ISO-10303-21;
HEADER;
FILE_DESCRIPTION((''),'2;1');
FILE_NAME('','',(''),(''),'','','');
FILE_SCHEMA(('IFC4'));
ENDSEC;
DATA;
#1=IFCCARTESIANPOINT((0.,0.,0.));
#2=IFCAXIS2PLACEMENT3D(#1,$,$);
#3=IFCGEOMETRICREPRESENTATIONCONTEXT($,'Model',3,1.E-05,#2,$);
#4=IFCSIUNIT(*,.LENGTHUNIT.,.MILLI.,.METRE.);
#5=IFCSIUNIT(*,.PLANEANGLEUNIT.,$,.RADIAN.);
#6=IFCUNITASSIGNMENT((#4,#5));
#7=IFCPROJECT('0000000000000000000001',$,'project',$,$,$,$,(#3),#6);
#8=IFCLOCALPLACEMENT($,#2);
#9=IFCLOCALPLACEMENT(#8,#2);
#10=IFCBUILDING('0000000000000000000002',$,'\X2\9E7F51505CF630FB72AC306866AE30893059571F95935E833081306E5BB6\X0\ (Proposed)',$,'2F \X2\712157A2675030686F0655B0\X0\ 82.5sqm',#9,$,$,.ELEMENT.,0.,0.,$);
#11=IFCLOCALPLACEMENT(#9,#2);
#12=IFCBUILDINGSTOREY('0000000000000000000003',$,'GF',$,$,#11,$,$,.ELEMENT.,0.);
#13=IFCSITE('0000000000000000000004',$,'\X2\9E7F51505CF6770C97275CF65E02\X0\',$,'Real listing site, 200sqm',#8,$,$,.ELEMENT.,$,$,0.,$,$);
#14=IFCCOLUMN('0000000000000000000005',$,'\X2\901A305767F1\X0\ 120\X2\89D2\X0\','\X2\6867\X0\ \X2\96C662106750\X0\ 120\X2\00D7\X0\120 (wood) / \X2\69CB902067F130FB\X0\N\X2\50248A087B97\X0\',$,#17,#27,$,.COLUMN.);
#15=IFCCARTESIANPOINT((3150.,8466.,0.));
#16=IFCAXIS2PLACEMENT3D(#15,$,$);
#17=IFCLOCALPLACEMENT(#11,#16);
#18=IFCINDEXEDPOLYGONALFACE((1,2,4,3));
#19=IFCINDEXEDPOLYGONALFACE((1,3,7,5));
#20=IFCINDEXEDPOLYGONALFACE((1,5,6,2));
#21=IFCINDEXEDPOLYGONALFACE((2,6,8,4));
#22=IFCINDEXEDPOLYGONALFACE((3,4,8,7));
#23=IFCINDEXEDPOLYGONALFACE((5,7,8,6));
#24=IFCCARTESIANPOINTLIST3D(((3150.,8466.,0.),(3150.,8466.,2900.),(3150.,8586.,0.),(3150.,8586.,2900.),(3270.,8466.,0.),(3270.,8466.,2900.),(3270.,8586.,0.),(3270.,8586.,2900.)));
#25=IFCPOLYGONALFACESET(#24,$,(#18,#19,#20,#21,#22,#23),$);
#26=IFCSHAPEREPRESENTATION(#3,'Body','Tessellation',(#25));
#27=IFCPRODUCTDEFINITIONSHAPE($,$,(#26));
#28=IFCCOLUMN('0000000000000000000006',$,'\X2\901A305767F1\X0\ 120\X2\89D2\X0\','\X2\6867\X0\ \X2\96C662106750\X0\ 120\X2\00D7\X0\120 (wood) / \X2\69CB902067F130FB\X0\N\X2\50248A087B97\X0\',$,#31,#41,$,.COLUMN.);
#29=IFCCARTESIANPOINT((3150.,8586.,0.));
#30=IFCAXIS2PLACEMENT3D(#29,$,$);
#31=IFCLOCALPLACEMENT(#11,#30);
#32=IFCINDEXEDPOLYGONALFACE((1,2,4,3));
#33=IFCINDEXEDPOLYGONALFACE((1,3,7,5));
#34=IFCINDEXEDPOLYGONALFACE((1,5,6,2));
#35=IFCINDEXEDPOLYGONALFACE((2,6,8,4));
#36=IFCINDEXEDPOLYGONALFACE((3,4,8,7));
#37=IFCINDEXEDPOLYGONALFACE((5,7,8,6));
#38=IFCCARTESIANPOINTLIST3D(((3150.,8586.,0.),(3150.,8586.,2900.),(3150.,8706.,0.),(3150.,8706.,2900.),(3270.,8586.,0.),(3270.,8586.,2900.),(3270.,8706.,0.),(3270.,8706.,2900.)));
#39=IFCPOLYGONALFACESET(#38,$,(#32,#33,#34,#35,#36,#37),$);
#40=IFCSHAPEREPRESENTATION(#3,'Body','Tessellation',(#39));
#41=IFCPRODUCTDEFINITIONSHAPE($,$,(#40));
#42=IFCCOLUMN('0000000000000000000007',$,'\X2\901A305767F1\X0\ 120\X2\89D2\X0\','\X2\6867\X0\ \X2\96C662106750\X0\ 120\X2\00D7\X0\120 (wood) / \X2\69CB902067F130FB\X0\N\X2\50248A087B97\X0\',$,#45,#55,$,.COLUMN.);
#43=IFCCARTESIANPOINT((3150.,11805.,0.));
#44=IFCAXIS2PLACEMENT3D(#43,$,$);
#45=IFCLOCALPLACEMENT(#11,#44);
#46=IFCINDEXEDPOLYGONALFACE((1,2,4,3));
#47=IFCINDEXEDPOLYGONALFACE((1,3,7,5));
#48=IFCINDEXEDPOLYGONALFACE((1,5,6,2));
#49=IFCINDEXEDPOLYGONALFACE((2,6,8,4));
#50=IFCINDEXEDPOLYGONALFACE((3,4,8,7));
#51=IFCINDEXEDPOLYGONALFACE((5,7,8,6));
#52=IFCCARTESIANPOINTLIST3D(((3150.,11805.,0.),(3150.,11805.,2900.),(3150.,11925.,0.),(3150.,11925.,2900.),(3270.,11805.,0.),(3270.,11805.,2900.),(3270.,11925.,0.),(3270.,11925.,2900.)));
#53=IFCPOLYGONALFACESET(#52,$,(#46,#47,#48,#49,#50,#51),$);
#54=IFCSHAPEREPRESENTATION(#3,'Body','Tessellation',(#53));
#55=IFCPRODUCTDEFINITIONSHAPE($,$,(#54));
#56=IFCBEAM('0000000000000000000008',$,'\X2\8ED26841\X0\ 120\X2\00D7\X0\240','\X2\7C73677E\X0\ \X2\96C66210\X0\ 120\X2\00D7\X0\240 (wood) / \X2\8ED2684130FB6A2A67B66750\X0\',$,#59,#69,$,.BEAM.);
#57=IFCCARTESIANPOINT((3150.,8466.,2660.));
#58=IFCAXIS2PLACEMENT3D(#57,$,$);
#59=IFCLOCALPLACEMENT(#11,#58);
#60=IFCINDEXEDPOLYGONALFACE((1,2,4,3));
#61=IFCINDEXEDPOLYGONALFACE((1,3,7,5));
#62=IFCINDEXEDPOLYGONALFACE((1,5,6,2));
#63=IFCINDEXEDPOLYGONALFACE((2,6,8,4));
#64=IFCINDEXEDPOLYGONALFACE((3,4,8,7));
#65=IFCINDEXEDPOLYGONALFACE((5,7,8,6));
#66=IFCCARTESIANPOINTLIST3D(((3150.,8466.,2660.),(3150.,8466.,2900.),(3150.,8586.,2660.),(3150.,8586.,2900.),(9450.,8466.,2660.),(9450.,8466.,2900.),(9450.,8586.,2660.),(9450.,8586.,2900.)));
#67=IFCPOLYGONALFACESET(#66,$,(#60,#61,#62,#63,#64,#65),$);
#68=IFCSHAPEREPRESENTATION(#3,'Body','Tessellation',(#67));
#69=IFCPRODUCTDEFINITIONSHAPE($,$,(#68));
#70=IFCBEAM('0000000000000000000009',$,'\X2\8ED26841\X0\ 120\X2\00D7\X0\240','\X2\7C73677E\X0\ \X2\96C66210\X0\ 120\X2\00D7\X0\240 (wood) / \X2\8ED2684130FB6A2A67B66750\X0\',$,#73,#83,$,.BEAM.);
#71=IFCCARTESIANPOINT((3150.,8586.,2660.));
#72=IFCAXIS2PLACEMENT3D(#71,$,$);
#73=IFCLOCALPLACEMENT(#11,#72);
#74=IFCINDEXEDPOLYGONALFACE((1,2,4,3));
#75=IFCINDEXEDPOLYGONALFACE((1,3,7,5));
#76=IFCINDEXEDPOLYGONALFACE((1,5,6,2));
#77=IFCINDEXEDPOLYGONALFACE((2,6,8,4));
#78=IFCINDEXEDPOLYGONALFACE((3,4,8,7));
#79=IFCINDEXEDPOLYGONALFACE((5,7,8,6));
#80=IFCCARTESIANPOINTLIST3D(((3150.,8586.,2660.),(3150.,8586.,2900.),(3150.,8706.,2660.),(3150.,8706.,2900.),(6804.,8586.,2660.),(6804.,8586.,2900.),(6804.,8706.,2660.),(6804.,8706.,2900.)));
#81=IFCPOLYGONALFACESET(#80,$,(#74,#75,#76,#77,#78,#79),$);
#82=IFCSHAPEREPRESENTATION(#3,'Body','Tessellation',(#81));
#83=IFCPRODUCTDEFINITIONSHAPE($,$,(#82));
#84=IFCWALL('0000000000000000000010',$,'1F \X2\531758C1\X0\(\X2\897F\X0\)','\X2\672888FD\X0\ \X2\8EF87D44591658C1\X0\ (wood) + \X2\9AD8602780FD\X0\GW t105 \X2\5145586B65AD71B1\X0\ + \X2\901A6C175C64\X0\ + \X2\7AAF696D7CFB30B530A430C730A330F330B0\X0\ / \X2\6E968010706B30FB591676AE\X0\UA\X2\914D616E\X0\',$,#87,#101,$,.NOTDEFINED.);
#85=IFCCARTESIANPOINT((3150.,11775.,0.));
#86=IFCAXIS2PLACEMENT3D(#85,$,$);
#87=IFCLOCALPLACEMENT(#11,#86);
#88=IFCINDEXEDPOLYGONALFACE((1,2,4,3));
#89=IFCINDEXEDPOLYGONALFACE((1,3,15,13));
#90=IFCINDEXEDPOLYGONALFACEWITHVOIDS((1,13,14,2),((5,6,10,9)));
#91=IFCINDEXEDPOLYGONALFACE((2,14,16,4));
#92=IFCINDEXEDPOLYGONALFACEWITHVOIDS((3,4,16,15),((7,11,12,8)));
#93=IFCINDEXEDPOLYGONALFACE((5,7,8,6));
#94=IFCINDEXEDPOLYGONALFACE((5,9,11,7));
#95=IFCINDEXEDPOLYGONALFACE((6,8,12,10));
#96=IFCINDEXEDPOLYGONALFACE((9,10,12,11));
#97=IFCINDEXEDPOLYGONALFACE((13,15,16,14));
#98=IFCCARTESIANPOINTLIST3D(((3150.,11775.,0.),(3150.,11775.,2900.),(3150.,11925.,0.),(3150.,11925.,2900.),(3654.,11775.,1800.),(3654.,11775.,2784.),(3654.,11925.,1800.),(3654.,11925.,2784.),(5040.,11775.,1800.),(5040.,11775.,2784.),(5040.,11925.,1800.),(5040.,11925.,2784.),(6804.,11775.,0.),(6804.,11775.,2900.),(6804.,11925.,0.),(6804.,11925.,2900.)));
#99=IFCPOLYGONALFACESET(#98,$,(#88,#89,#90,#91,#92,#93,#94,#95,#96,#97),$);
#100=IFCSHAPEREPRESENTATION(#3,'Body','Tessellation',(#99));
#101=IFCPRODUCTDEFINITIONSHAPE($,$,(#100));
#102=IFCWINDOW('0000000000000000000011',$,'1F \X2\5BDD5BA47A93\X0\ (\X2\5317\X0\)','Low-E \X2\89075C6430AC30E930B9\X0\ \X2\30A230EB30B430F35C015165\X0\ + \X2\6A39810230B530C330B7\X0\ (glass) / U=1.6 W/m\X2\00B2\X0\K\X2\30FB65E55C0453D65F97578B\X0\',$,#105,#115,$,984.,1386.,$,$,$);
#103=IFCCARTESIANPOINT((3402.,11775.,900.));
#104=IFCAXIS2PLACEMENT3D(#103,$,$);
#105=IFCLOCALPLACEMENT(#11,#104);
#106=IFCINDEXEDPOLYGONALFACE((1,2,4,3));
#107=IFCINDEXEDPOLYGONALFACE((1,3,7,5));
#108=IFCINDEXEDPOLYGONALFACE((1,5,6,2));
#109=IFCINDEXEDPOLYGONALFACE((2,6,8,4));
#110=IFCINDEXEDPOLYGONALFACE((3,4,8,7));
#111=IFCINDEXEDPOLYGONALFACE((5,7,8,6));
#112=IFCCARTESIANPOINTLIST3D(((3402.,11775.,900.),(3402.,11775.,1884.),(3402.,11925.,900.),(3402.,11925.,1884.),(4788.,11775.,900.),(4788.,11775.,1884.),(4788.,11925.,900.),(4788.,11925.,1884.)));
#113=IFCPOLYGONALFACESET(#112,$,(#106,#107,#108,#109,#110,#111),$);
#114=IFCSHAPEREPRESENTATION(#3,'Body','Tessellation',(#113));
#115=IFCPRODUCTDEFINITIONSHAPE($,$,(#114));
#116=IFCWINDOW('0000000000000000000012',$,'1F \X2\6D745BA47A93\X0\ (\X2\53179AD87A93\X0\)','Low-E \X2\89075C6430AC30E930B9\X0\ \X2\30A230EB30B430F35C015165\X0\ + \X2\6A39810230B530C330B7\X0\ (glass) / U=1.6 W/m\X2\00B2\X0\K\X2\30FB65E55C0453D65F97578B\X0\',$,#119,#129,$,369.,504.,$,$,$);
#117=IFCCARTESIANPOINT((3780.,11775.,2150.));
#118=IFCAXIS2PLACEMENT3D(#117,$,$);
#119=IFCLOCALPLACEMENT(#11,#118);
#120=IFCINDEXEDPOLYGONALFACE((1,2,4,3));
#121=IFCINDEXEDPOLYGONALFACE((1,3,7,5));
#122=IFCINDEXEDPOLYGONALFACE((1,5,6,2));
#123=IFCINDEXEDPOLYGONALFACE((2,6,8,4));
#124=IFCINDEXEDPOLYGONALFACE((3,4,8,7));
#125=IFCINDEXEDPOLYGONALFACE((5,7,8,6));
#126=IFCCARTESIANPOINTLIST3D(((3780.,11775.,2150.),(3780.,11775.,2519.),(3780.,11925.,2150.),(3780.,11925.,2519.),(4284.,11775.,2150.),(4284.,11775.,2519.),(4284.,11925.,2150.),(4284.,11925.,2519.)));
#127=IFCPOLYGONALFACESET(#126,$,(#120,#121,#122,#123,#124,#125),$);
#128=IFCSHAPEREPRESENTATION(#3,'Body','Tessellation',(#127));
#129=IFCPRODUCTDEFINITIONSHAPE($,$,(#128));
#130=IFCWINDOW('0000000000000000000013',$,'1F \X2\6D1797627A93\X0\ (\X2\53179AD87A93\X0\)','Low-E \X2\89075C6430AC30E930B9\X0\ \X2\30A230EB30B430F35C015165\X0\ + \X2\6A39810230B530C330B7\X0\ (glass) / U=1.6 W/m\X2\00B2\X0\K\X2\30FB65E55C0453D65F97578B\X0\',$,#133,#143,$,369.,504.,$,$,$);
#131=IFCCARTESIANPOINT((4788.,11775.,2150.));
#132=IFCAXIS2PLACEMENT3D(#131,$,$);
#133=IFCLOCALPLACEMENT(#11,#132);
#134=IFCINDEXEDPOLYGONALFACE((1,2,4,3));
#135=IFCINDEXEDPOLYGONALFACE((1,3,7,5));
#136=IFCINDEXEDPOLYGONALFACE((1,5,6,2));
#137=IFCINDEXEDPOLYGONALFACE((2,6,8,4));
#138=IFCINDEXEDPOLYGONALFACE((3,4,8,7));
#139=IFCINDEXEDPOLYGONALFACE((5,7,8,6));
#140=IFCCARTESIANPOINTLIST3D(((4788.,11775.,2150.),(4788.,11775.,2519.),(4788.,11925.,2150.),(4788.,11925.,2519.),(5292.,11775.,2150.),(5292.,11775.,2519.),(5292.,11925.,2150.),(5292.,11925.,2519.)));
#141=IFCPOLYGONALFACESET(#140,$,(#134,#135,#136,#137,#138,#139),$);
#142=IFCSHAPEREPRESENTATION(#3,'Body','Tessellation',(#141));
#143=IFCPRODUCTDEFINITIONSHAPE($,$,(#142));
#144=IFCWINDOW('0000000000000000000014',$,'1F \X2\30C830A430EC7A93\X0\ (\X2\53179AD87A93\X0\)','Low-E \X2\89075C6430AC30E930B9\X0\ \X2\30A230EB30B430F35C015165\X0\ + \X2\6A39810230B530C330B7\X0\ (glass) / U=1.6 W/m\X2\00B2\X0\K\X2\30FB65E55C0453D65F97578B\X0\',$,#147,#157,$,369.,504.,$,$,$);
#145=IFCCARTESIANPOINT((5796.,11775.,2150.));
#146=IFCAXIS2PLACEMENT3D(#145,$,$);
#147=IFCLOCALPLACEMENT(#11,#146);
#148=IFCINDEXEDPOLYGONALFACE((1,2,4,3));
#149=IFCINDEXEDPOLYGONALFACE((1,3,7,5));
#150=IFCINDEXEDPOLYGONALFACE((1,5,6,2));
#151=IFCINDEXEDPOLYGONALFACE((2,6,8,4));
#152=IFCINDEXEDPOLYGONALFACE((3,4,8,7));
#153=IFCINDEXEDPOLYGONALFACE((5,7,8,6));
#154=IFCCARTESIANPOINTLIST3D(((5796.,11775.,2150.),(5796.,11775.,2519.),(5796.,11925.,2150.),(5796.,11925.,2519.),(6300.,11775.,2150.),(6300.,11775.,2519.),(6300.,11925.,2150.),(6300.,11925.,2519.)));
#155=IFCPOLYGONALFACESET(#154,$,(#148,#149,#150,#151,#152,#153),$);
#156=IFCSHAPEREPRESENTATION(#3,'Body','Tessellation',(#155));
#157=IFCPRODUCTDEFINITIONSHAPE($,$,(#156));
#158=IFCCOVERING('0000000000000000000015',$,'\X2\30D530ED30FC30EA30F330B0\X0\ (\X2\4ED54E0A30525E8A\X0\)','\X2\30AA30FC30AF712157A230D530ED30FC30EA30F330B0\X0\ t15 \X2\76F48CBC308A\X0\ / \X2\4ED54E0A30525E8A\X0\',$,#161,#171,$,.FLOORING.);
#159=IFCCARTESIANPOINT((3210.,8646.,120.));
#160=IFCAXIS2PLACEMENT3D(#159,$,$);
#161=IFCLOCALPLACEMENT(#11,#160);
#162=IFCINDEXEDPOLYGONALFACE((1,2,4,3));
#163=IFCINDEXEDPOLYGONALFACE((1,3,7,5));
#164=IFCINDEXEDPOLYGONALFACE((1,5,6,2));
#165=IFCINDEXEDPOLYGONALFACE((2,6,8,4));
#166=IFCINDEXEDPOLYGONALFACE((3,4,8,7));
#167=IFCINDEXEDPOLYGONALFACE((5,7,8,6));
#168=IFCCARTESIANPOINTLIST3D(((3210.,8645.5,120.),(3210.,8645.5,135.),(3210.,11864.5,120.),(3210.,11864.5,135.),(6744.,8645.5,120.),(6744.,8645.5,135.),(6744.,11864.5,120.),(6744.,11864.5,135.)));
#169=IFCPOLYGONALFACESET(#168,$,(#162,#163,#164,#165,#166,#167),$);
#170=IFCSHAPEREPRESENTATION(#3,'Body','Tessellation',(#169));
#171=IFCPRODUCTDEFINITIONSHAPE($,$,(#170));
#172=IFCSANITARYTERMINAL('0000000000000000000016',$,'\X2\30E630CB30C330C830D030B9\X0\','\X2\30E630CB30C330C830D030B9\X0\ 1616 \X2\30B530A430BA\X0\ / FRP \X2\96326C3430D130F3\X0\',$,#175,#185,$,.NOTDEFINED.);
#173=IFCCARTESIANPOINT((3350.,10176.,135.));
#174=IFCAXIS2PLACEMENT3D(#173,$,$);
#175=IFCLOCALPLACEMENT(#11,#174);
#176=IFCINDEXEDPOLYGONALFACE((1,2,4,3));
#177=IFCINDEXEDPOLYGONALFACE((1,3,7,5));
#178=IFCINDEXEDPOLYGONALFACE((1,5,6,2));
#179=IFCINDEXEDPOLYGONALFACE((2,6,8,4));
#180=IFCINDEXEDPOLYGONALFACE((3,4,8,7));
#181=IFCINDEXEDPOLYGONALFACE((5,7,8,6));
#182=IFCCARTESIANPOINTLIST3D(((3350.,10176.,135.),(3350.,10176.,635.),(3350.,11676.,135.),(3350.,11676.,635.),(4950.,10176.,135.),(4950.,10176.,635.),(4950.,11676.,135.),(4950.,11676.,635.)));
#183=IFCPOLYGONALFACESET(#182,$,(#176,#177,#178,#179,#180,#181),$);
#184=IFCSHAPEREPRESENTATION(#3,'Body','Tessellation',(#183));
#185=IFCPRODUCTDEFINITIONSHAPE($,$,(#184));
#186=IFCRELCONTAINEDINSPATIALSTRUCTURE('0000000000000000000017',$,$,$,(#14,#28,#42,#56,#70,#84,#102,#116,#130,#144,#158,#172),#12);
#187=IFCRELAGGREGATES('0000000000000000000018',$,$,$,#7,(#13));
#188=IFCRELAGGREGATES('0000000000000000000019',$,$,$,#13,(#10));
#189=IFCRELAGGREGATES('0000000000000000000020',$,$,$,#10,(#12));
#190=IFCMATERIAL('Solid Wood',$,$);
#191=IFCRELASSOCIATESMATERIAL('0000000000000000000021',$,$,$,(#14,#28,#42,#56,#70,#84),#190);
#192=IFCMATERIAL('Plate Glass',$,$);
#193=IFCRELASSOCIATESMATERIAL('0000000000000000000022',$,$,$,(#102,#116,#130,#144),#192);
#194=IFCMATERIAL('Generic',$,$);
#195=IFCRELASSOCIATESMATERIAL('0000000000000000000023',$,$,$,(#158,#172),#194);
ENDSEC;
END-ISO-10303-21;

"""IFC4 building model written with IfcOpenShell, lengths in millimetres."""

from ifc_helpers import new_model, si_unit, frame, frame_2d, origin, place, context, project, spatial, rectangle, extrude, material, element, fill, save


model = new_model("IFC4")

# Units and contexts
model_context = context("Model", 3, precision=1e-05, world=origin())
ifc_project = project(units=[si_unit("LENGTHUNIT", "METRE", prefix="MILLI"), si_unit("PLANEANGLEUNIT", "RADIAN")], contexts=[model_context])

# Site, building, storey
site_placement = place(None, origin())
site = spatial("IfcSite", under=ifc_project, at=site_placement, Name="鹿児島県霧島市", ObjectType="Real listing site, 200sqm", CompositionType="ELEMENT", RefElevation=0.0)
building_placement = place(site_placement, origin())
building = spatial("IfcBuilding", under=site, at=building_placement, Name="鹿児島・犬と暮らす土間広めの家 (Proposed)", ObjectType="2F 無垢材と漆喰 82.5sqm", CompositionType="ELEMENT", ElevationOfRefHeight=0.0, ElevationOfTerrain=0.0)
storey_placement = place(building_placement, origin())
storey = spatial("IfcBuildingStorey", under=building, at=storey_placement, Name="GF", CompositionType="ELEMENT", Elevation=0.0)

# Columns
ifc_material_1 = material(Name="Solid Wood")
column_1_placement = place(storey_placement, frame((3150.0, 8466.0, 0.0)))
element("IfcColumn", 1, at=column_1_placement, inside=storey, material=ifc_material_1, Name="通し柱 120角", Description="桧 集成材 120×120 (wood) / 構造柱・N値計算", PredefinedType="COLUMN", context=model_context, shape_type="SweptSolid", body=[
    extrude(rectangle(XDim=120.0, YDim=120.0, at=frame_2d((60.0, 60.0))), frame((3150.0, 8466.0, 0.0)), (0.0, 0.0, 1.0), 2900.0),
])
column_2_placement = place(storey_placement, frame((3150.0, 8586.0, 0.0)))
element("IfcColumn", 2, at=column_2_placement, inside=storey, material=ifc_material_1, Name="通し柱 120角", Description="桧 集成材 120×120 (wood) / 構造柱・N値計算", PredefinedType="COLUMN", context=model_context, shape_type="SweptSolid", body=[
    extrude(rectangle(XDim=120.0, YDim=120.0, at=frame_2d((60.0, 60.0))), frame((3150.0, 8586.0, 0.0)), (0.0, 0.0, 1.0), 2900.0),
])
column_3_placement = place(storey_placement, frame((3150.0, 11805.0, 0.0)))
element("IfcColumn", 3, at=column_3_placement, inside=storey, material=ifc_material_1, Name="通し柱 120角", Description="桧 集成材 120×120 (wood) / 構造柱・N値計算", PredefinedType="COLUMN", context=model_context, shape_type="SweptSolid", body=[
    extrude(rectangle(XDim=120.0, YDim=120.0, at=frame_2d((60.0, 60.0))), frame((3150.0, 11805.0, 0.0)), (0.0, 0.0, 1.0), 2900.0),
])

# Beams
beam_1_placement = place(storey_placement, frame((3150.0, 8466.0, 2660.0)))
element("IfcBeam", 4, at=beam_1_placement, inside=storey, material=ifc_material_1, Name="軒桁 120×240", Description="米松 集成 120×240 (wood) / 軒桁・横架材", PredefinedType="BEAM", context=model_context, shape_type="SweptSolid", body=[
    extrude(rectangle(XDim=6300.0, YDim=120.0, at=frame_2d((3150.0, 60.0))), frame((3150.0, 8466.0, 2660.0)), (0.0, 0.0, 1.0), 240.0),
])
beam_2_placement = place(storey_placement, frame((3150.0, 8586.0, 2660.0)))
element("IfcBeam", 5, at=beam_2_placement, inside=storey, material=ifc_material_1, Name="軒桁 120×240", Description="米松 集成 120×240 (wood) / 軒桁・横架材", PredefinedType="BEAM", context=model_context, shape_type="SweptSolid", body=[
    extrude(rectangle(XDim=3654.0, YDim=120.0, at=frame_2d((1827.0, 60.0))), frame((3150.0, 8586.0, 2660.0)), (0.0, 0.0, 1.0), 240.0),
])

# Wall, openings, windows
wall_1_placement = place(storey_placement, frame((3150.0, 11775.0, 0.0)))
wall_1 = element("IfcWall", 6, at=wall_1_placement, inside=storey, material=ifc_material_1, Name="1F 北壁(西)", Description="木製 軸組外壁 (wood) + 高性能GW t105 充填断熱 + 通気層 + 窯業系サイディング / 準耐火・外皮UA配慮", PredefinedType="NOTDEFINED", context=model_context, shape_type="SweptSolid", body=[
    extrude(rectangle(XDim=3654.0, YDim=150.0, at=frame_2d((1827.0, 75.0))), frame((3150.0, 11775.0, 0.0)), (0.0, 0.0, 1.0), 2900.0),
])
opening_1_placement = place(storey_placement, frame((3402.0, 11775.0, 900.0)))
opening_1 = element("IfcOpeningElement", 7, at=opening_1_placement, cuts=wall_1, PredefinedType="NOTDEFINED", context=model_context, shape_type="SweptSolid", body=[
    extrude(rectangle(XDim=1386.0, YDim=150.0, at=frame_2d((693.0, 75.0))), frame((3402.0, 11775.0, 900.0)), (0.0, 0.0, 1.0), 984.0),
])
opening_2_placement = place(storey_placement, frame((3780.0, 11775.0, 2150.0)))
opening_2 = element("IfcOpeningElement", 8, at=opening_2_placement, cuts=wall_1, PredefinedType="NOTDEFINED", context=model_context, shape_type="SweptSolid", body=[
    extrude(rectangle(XDim=504.0, YDim=150.0, at=frame_2d((252.0, 75.0))), frame((3780.0, 11775.0, 2150.0)), (0.0, 0.0, 1.0), 369.0),
])
opening_3_placement = place(storey_placement, frame((4788.0, 11775.0, 2150.0)))
opening_3 = element("IfcOpeningElement", 9, at=opening_3_placement, cuts=wall_1, PredefinedType="NOTDEFINED", context=model_context, shape_type="SweptSolid", body=[
    extrude(rectangle(XDim=504.0, YDim=150.0, at=frame_2d((252.0, 75.0))), frame((4788.0, 11775.0, 2150.0)), (0.0, 0.0, 1.0), 369.0),
])
opening_4_placement = place(storey_placement, frame((5796.0, 11775.0, 2150.0)))
opening_4 = element("IfcOpeningElement", 10, at=opening_4_placement, cuts=wall_1, PredefinedType="NOTDEFINED", context=model_context, shape_type="SweptSolid", body=[
    extrude(rectangle(XDim=504.0, YDim=150.0, at=frame_2d((252.0, 75.0))), frame((5796.0, 11775.0, 2150.0)), (0.0, 0.0, 1.0), 369.0),
])
ifc_material_2 = material(Name="Plate Glass")
window_1_placement = place(storey_placement, frame((3402.0, 11775.0, 900.0)))
window_1 = element("IfcWindow", 11, at=window_1_placement, inside=storey, material=ifc_material_2, Name="1F 寝室窓 (北)", Description="Low-E 複層ガラス アルゴン封入 + 樹脂サッシ (glass) / U=1.6 W/m²K・日射取得型", OverallHeight=984.0, OverallWidth=1386.0, context=model_context, shape_type="SweptSolid", body=[
    extrude(rectangle(XDim=1386.0, YDim=150.0, at=frame_2d((693.0, 75.0))), frame((3402.0, 11775.0, 900.0)), (0.0, 0.0, 1.0), 984.0),
])
fill(opening_1, window_1)
window_2_placement = place(storey_placement, frame((3780.0, 11775.0, 2150.0)))
window_2 = element("IfcWindow", 12, at=window_2_placement, inside=storey, material=ifc_material_2, Name="1F 浴室窓 (北高窓)", Description="Low-E 複層ガラス アルゴン封入 + 樹脂サッシ (glass) / U=1.6 W/m²K・日射取得型", OverallHeight=369.0, OverallWidth=504.0, context=model_context, shape_type="SweptSolid", body=[
    extrude(rectangle(XDim=504.0, YDim=150.0, at=frame_2d((252.0, 75.0))), frame((3780.0, 11775.0, 2150.0)), (0.0, 0.0, 1.0), 369.0),
])
fill(opening_2, window_2)
window_3_placement = place(storey_placement, frame((4788.0, 11775.0, 2150.0)))
window_3 = element("IfcWindow", 13, at=window_3_placement, inside=storey, material=ifc_material_2, Name="1F 洗面窓 (北高窓)", Description="Low-E 複層ガラス アルゴン封入 + 樹脂サッシ (glass) / U=1.6 W/m²K・日射取得型", OverallHeight=369.0, OverallWidth=504.0, context=model_context, shape_type="SweptSolid", body=[
    extrude(rectangle(XDim=504.0, YDim=150.0, at=frame_2d((252.0, 75.0))), frame((4788.0, 11775.0, 2150.0)), (0.0, 0.0, 1.0), 369.0),
])
fill(opening_3, window_3)
window_4_placement = place(storey_placement, frame((5796.0, 11775.0, 2150.0)))
window_4 = element("IfcWindow", 14, at=window_4_placement, inside=storey, material=ifc_material_2, Name="1F トイレ窓 (北高窓)", Description="Low-E 複層ガラス アルゴン封入 + 樹脂サッシ (glass) / U=1.6 W/m²K・日射取得型", OverallHeight=369.0, OverallWidth=504.0, context=model_context, shape_type="SweptSolid", body=[
    extrude(rectangle(XDim=504.0, YDim=150.0, at=frame_2d((252.0, 75.0))), frame((5796.0, 11775.0, 2150.0)), (0.0, 0.0, 1.0), 369.0),
])
fill(opening_4, window_4)

# Covering
ifc_material_3 = material(Name="Generic")
covering_placement = place(storey_placement, frame((3210.0, 8646.0, 120.0)))
element("IfcCovering", 15, at=covering_placement, inside=storey, material=ifc_material_3, Name="フローリング (仕上げ床)", Description="オーク無垢フローリング t15 直貼り / 仕上げ床", PredefinedType="FLOORING", context=model_context, shape_type="SweptSolid", body=[
    extrude(rectangle(XDim=3534.0, YDim=3219.0, at=frame_2d((1767.0, 1609.0))), frame((3210.0, 8646.0, 120.0)), (0.0, 0.0, 1.0), 15.0),
])

# Sanitary terminal
sanitary_terminal_placement = place(storey_placement, frame((3350.0, 10176.0, 135.0)))
element("IfcSanitaryTerminal", 16, at=sanitary_terminal_placement, inside=storey, material=ifc_material_3, Name="ユニットバス", Description="ユニットバス 1616 サイズ / FRP 防水パン", PredefinedType="NOTDEFINED", context=model_context, shape_type="SweptSolid", body=[
    extrude(rectangle(XDim=1600.0, YDim=1500.0, at=frame_2d((800.0, 750.0))), frame((3350.0, 10176.0, 135.0)), (0.0, 0.0, 1.0), 500.0),
])

save(model, "model.ifc")
